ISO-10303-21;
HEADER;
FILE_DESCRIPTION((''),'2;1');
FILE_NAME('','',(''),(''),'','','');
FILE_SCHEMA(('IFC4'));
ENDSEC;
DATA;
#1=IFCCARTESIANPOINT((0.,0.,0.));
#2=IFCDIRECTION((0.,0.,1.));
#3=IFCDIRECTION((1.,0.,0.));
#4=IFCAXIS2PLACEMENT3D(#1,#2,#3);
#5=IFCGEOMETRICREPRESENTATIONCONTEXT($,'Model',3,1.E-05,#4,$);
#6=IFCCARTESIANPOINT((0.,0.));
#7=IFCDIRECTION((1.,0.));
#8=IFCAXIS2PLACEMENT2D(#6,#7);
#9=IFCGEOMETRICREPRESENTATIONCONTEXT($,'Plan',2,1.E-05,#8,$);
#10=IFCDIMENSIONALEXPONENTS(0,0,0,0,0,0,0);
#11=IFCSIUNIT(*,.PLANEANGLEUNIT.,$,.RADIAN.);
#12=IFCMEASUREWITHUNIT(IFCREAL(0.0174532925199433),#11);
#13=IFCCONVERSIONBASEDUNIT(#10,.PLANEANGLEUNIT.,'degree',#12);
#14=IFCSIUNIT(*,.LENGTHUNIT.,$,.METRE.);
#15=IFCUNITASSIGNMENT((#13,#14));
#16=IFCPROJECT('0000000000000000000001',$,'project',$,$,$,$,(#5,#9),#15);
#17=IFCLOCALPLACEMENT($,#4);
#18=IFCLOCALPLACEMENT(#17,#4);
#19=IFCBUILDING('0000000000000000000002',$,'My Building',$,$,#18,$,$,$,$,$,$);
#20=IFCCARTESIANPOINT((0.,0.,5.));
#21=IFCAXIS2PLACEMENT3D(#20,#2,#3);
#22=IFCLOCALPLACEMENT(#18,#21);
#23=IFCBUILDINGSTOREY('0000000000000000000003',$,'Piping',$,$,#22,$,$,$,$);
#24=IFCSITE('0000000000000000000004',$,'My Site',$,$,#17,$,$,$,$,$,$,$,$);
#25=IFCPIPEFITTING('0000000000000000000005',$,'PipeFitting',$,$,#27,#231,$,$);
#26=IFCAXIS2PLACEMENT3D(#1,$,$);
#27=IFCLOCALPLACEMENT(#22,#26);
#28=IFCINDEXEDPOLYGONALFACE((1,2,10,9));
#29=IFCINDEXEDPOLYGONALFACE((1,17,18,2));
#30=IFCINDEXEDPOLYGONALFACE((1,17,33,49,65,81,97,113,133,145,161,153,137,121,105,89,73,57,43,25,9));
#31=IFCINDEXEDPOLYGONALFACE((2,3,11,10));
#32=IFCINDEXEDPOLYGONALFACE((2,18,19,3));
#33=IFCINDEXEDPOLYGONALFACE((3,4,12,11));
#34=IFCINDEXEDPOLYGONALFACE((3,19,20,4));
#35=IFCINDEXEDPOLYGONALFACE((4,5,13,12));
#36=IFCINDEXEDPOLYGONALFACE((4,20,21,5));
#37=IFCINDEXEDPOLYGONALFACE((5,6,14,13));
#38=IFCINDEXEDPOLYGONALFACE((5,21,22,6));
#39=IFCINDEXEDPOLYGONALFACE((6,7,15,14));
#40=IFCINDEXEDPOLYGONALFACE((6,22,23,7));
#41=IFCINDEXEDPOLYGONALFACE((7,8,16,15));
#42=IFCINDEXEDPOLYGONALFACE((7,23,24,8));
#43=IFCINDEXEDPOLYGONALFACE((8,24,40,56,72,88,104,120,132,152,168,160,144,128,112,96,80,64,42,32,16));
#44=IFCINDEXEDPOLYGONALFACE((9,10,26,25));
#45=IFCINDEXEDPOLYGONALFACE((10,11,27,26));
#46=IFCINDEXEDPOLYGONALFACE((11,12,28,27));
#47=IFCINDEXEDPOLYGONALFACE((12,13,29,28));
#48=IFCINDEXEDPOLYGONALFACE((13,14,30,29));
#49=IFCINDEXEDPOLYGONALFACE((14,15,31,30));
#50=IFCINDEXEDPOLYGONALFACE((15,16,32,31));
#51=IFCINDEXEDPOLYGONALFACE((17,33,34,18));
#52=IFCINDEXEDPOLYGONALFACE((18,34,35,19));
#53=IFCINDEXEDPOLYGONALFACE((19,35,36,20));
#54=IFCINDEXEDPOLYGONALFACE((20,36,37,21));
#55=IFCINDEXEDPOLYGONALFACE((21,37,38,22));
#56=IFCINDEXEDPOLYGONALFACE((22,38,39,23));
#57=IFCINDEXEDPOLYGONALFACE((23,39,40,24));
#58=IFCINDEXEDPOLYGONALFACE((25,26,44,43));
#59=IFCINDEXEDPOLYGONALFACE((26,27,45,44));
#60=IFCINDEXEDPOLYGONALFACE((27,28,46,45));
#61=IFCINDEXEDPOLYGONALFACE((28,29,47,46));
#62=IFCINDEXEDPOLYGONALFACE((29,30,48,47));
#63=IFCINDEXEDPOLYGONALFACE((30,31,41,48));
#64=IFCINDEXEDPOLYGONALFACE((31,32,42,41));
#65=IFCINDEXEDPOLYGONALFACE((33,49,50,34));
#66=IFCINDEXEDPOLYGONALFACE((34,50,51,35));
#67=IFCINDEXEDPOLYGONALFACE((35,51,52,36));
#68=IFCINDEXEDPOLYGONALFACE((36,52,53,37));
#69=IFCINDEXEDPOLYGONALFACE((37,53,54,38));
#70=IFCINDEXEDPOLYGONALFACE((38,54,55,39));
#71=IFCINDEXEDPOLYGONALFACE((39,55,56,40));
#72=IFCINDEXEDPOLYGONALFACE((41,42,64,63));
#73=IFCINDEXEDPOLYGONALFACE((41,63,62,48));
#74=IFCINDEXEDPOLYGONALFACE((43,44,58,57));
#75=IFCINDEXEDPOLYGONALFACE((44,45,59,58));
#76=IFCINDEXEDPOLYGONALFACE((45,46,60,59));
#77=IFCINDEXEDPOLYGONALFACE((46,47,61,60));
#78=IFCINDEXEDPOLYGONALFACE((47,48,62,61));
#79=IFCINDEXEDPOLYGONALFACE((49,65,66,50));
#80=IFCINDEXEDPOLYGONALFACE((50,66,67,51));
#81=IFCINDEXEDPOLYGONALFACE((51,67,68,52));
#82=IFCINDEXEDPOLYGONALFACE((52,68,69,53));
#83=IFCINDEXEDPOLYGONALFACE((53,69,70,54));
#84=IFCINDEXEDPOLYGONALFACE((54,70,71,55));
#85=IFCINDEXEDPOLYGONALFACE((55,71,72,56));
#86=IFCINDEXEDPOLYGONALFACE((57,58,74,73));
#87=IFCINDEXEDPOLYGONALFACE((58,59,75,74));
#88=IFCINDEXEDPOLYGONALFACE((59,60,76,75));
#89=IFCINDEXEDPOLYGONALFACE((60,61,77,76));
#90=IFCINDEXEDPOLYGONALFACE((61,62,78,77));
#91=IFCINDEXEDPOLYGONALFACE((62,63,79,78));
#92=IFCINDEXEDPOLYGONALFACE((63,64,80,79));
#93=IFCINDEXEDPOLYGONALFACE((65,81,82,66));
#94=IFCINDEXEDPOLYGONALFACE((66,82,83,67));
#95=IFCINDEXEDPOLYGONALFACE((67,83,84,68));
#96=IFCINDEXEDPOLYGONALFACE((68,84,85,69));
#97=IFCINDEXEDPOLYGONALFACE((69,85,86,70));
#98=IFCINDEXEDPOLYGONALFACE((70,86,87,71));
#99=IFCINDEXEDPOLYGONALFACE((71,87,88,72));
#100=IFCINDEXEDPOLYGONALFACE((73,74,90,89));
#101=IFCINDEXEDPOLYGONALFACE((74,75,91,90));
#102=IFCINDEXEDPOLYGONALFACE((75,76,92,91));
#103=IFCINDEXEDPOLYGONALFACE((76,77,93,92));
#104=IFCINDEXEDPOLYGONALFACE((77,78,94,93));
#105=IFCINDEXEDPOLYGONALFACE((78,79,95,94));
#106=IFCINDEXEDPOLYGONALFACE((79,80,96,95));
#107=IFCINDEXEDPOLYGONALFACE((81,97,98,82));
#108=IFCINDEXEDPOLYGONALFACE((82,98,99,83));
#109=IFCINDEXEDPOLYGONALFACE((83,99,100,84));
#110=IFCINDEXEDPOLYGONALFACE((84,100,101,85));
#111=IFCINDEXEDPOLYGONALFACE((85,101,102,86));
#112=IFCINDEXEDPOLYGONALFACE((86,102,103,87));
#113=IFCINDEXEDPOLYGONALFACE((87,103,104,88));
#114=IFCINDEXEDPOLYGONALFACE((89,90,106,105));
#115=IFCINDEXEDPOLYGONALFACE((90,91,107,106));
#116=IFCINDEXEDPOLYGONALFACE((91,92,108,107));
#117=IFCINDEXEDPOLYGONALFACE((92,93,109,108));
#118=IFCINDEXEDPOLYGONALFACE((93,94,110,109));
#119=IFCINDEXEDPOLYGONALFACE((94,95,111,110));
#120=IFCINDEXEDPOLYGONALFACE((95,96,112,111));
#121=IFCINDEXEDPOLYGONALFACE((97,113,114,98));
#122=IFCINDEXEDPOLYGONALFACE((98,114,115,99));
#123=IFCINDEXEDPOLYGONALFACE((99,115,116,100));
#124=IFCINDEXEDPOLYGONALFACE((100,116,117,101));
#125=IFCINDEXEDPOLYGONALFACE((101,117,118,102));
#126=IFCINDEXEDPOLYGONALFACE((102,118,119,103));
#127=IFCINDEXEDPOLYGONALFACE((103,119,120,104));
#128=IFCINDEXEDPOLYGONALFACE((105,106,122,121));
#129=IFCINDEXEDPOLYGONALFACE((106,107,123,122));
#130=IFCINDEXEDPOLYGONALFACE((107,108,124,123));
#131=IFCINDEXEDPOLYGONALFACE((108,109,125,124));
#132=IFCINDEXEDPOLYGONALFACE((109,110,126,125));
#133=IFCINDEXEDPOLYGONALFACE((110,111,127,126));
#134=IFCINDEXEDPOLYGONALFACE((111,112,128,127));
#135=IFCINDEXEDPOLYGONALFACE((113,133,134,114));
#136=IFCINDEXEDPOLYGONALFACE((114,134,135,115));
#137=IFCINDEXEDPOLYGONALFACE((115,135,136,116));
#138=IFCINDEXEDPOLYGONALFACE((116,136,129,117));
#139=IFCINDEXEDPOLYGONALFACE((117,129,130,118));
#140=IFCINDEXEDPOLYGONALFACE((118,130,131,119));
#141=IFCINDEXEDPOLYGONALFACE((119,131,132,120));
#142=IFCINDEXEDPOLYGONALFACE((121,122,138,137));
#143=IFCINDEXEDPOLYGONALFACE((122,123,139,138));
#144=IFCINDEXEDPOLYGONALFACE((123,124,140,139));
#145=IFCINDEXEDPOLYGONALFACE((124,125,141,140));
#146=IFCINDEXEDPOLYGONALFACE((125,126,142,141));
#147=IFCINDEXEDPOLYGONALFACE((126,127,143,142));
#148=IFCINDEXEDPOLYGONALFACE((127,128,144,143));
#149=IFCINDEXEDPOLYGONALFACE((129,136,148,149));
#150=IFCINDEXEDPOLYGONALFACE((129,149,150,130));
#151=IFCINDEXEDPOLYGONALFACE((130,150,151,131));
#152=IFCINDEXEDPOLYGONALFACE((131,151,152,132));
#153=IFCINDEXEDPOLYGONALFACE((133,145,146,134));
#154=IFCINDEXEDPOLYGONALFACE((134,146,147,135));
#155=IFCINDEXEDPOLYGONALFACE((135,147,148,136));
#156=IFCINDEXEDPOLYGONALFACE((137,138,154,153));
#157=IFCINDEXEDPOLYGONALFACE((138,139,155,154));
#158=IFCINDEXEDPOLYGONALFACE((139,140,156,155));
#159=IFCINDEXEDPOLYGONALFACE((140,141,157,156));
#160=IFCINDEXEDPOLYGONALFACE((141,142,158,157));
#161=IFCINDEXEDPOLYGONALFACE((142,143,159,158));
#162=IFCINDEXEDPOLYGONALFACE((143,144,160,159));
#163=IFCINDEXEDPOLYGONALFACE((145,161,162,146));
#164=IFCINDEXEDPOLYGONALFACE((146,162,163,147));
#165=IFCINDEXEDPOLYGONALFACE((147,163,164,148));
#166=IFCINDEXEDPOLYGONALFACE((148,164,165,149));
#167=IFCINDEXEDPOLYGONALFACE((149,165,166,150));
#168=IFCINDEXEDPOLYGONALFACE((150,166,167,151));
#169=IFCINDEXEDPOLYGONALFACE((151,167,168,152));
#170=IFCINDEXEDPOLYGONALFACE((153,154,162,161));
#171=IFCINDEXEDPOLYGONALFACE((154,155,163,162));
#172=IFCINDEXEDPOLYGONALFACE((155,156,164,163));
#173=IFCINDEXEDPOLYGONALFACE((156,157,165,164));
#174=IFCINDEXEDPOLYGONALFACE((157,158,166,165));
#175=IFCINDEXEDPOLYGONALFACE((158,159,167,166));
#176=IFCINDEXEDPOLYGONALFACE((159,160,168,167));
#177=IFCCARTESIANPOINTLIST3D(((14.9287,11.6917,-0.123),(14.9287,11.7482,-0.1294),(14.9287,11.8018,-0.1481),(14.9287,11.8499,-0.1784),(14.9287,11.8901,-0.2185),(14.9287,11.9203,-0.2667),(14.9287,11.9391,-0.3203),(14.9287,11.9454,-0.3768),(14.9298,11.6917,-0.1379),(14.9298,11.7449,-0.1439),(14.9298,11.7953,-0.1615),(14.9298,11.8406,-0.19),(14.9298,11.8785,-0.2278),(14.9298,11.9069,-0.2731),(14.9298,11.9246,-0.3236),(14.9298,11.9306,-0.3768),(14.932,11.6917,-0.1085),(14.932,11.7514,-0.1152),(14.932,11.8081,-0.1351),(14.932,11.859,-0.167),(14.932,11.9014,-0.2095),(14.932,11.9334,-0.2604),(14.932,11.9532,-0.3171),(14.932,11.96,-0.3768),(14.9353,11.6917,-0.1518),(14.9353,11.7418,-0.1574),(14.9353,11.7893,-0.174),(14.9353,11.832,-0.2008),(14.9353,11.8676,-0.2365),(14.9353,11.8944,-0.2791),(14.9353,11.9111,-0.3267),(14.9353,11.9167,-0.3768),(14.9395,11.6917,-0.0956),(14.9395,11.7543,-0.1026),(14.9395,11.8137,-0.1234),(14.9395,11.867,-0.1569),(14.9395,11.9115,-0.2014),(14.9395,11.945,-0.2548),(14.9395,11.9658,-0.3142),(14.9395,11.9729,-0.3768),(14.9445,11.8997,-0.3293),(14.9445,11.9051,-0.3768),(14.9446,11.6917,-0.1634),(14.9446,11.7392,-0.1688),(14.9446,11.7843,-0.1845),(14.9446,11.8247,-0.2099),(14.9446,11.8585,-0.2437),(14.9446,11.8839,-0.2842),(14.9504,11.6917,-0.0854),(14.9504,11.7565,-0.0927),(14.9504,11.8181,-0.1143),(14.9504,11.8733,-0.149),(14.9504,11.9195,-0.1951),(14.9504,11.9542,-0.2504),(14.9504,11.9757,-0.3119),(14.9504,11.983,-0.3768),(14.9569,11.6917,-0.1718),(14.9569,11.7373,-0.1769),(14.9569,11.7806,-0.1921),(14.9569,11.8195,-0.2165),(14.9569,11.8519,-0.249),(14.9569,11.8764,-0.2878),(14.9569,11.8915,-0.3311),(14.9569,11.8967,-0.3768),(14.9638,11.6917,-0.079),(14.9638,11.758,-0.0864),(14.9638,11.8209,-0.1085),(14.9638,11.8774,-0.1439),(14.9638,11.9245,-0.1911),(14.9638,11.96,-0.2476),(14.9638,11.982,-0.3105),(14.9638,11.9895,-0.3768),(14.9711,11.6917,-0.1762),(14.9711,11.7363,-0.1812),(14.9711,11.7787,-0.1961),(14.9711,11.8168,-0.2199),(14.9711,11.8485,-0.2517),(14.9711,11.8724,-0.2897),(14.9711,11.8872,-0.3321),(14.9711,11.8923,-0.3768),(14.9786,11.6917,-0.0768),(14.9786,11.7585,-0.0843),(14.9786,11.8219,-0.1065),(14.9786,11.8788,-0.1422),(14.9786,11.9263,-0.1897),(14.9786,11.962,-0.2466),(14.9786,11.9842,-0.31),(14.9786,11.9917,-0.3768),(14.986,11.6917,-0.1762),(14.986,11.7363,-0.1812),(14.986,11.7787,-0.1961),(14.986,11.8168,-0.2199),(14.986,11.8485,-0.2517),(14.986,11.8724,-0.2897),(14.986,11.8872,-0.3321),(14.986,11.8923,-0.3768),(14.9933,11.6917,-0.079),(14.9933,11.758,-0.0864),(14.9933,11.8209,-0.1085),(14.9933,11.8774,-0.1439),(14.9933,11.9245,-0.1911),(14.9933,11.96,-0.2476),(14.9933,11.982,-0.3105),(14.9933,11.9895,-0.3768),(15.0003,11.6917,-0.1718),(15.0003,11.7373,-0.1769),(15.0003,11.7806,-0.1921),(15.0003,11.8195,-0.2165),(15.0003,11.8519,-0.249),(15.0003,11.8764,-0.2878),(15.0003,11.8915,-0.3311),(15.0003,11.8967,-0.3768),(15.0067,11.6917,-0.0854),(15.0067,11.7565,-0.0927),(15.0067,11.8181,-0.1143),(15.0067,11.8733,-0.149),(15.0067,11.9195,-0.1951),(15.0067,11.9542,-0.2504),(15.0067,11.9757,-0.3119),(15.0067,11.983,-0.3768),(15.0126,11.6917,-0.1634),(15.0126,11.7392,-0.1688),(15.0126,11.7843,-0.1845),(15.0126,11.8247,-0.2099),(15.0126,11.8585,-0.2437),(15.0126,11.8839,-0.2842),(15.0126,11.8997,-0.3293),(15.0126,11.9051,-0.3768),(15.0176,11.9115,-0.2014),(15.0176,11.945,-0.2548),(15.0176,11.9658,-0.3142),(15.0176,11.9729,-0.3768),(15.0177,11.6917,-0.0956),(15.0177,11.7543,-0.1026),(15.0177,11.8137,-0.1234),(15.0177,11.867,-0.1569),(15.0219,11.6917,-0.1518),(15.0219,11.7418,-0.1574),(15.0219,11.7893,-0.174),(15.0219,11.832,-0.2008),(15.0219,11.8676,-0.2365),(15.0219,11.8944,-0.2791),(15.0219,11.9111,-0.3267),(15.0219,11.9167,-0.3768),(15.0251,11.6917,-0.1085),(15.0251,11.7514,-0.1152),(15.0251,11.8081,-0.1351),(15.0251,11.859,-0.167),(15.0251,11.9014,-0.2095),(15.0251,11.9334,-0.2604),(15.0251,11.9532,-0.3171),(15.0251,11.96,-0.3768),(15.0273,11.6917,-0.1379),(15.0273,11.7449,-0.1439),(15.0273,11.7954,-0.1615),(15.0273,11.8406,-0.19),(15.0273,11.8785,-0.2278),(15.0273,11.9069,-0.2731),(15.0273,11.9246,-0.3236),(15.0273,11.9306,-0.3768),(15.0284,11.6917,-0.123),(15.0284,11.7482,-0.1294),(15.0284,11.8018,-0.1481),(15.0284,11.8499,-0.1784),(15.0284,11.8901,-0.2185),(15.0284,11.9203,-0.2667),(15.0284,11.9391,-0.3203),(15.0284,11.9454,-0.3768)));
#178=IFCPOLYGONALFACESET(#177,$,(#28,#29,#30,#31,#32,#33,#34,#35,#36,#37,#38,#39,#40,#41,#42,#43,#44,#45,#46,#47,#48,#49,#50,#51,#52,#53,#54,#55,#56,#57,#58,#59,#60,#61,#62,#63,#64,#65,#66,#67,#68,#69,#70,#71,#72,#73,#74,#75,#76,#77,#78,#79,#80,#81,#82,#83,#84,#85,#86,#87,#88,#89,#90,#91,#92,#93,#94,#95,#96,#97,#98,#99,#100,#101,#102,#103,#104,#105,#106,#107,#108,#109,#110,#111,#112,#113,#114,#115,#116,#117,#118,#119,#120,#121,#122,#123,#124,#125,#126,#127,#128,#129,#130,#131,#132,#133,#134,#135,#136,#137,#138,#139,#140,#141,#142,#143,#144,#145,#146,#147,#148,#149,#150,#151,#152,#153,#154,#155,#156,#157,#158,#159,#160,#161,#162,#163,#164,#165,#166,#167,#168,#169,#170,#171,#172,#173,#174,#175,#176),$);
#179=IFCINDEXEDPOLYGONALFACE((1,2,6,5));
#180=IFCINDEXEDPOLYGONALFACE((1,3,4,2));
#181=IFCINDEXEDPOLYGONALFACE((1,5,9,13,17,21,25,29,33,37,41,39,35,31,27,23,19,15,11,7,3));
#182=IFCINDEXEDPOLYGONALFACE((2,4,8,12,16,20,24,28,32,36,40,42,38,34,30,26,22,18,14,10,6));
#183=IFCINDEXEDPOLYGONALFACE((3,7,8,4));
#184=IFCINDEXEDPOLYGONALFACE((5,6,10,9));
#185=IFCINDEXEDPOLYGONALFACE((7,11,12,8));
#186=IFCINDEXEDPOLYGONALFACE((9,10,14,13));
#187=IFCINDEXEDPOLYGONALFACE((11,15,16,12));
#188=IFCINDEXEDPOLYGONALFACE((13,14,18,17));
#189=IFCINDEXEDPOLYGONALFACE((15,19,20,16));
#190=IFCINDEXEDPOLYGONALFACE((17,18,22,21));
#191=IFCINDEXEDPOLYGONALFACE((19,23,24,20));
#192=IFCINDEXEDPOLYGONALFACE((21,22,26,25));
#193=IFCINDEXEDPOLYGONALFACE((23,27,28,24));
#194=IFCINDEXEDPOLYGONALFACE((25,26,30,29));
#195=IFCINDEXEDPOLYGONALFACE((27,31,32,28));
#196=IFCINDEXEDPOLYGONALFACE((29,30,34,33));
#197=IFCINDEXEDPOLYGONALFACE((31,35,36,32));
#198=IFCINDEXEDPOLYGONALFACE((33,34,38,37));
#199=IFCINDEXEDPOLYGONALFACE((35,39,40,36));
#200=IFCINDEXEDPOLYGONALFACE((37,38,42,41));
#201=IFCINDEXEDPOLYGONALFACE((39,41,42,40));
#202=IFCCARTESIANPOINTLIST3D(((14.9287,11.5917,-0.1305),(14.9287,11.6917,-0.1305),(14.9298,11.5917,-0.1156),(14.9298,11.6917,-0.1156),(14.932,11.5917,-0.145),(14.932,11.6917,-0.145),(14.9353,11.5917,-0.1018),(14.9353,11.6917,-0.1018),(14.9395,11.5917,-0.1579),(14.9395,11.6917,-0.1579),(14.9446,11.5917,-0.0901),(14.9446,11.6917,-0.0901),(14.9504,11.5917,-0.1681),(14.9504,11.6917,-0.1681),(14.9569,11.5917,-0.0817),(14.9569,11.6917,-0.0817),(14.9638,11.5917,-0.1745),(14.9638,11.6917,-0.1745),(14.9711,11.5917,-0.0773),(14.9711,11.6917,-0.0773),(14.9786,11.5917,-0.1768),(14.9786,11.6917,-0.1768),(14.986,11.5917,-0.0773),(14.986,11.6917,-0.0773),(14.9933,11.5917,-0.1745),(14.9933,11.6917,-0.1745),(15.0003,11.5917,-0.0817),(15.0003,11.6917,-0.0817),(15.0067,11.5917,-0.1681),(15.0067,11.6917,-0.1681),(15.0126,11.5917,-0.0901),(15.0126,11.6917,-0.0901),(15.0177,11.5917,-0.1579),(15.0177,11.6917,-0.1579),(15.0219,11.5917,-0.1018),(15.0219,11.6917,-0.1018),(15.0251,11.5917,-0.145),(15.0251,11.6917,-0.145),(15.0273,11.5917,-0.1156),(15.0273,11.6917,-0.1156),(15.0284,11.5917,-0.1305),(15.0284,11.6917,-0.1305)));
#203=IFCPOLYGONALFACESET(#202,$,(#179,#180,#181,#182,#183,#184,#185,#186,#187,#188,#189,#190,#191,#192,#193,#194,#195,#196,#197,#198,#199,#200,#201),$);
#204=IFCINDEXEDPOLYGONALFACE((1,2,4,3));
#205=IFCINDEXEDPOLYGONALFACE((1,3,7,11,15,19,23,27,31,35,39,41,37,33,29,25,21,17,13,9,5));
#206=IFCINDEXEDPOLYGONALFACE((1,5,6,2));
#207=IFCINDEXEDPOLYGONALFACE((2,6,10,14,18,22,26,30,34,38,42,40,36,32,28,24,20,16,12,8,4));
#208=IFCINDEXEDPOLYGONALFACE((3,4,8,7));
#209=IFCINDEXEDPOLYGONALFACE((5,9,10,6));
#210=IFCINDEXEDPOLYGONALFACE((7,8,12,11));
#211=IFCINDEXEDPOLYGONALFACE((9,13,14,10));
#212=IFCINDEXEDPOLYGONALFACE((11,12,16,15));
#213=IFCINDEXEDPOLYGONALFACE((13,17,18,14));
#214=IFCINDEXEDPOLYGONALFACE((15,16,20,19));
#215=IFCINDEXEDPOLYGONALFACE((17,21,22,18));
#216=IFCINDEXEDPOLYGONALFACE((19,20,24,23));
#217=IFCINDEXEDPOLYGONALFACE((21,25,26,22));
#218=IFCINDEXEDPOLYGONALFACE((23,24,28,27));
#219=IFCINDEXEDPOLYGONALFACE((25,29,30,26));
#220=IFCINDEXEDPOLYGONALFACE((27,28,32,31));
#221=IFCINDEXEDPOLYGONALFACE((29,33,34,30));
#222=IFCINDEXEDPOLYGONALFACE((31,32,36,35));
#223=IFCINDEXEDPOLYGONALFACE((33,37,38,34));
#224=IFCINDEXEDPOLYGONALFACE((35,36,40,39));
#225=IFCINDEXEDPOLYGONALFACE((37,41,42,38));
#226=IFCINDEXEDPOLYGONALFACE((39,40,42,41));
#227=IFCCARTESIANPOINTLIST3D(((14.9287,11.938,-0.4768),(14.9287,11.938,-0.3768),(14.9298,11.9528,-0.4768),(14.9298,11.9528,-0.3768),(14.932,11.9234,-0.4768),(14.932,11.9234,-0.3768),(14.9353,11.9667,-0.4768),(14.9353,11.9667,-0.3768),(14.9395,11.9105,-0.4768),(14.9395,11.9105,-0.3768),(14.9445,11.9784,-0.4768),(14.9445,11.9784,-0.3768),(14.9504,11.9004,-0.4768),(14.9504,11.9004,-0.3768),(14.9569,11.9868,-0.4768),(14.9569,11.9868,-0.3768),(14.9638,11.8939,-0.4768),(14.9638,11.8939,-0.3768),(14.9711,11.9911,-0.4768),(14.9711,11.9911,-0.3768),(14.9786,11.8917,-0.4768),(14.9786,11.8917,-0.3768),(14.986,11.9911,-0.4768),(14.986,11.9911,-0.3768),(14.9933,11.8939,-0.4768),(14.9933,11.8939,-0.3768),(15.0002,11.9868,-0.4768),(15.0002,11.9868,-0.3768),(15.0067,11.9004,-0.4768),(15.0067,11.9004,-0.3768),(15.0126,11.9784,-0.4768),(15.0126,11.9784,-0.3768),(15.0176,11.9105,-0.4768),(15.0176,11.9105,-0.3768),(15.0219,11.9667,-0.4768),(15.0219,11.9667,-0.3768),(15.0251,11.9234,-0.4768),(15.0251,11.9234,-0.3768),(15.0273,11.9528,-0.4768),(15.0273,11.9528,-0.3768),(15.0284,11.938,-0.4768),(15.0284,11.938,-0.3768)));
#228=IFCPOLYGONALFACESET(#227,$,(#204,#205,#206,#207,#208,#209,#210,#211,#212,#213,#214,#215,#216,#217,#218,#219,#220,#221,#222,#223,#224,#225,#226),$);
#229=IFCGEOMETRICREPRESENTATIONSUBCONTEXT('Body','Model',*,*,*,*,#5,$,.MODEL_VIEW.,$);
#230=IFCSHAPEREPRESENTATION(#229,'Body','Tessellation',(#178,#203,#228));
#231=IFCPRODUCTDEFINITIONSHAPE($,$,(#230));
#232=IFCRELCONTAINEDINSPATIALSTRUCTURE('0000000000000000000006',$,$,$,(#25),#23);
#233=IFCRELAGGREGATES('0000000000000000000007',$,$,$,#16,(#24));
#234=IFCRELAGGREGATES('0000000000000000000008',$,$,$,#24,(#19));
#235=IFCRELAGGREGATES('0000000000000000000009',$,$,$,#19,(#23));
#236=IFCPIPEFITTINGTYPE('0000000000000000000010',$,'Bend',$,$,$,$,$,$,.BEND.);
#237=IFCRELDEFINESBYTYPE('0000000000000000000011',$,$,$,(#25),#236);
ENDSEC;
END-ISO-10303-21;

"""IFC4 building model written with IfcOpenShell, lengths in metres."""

from ifc_helpers import new_model, entity, si_unit, converted_unit, frame, origin_with_axes, origin_2d_with_axis, place, context, subcontext, project, spatial, circle, extrude, source, transform, mapped, type_object, type_shapes, element, save


model = new_model("IFC4")

# Units and contexts
model_context = context("Model", 3, precision=1e-05, world=origin_with_axes())
plan_context = context("Plan", 2, precision=1e-05, world=origin_2d_with_axis())
body_context = subcontext(model_context, "Body", "Model", "MODEL_VIEW")
ifc_project = project(units=[converted_unit("PLANEANGLEUNIT", "degree", entity("IfcReal", 0.0174532925199433), si_unit("PLANEANGLEUNIT", "RADIAN"), dimensions=[0, 0, 0, 0, 0, 0, 0]), si_unit("LENGTHUNIT", "METRE")], contexts=[model_context, plan_context])

# Site, building, storey
site_placement = place(None, origin_with_axes())
site = spatial("IfcSite", under=ifc_project, at=site_placement, Name="My Site")
building_placement = place(site_placement, origin_with_axes())
building = spatial("IfcBuilding", under=site, at=building_placement, Name="My Building")
storey_placement = place(building_placement, frame((0.0, 0.0, 5.0), z_axis=(0.0, 0.0, 1.0), x_axis=(1.0, 0.0, 0.0)))
storey = spatial("IfcBuildingStorey", under=building, at=storey_placement, Name="Piping")

# Pipe fitting
pipe_fitting_type_1 = type_object("IfcPipeFittingType", Name="Bend", PredefinedType="BEND")
shared_shape = source(origin_with_axes(), body_context, "Body", "SolidModel", [
    entity("IfcSweptDiskSolid", entity("IfcIndexedPolyCurve", entity("IfcCartesianPointList3D", [[0.0, 0.0, -0.1], [0.0732, 0.0, -0.2768], [0.25, 0.0, -0.35]]), [entity("IfcArcIndex", [1, 2, 3])]), 0.05),
    extrude(circle(Radius=0.05), origin_with_axes(), (0.0, 0.0, -1.0), 0.1),
    extrude(circle(Radius=0.05), frame((0.25, 0.0, -0.35), z_axis=(1.0, 0.0, 0.0), x_axis=(0.0, 0.0, 1.0)), (0.0, 0.0, 1.0), 0.1),
])
type_shapes(pipe_fitting_type_1, [shared_shape])
for number, where, z_axis, x_axis, name in (
    (1, (14.9786, 11.5917, -0.1268), (0.00006, -1.0, 0.0), (0.0, 0.0, -1.0), "PipeFitting"),
):
    element("IfcPipeFitting", number, at=place(storey_placement, frame(where, z_axis=z_axis, x_axis=x_axis)), inside=storey, type_object=pipe_fitting_type_1, Name=name, context=body_context, shape_type="MappedRepresentation", body=[
        mapped(shared_shape, transform((0.0, 0.0, 0.0), x_axis=(1.0, 0.0, 0.0), y_axis=(0.0, 1.0, 0.0), z_axis=(0.0, 0.0, 1.0), scale=1.0)),
    ])

save(model, "model.ifc")
